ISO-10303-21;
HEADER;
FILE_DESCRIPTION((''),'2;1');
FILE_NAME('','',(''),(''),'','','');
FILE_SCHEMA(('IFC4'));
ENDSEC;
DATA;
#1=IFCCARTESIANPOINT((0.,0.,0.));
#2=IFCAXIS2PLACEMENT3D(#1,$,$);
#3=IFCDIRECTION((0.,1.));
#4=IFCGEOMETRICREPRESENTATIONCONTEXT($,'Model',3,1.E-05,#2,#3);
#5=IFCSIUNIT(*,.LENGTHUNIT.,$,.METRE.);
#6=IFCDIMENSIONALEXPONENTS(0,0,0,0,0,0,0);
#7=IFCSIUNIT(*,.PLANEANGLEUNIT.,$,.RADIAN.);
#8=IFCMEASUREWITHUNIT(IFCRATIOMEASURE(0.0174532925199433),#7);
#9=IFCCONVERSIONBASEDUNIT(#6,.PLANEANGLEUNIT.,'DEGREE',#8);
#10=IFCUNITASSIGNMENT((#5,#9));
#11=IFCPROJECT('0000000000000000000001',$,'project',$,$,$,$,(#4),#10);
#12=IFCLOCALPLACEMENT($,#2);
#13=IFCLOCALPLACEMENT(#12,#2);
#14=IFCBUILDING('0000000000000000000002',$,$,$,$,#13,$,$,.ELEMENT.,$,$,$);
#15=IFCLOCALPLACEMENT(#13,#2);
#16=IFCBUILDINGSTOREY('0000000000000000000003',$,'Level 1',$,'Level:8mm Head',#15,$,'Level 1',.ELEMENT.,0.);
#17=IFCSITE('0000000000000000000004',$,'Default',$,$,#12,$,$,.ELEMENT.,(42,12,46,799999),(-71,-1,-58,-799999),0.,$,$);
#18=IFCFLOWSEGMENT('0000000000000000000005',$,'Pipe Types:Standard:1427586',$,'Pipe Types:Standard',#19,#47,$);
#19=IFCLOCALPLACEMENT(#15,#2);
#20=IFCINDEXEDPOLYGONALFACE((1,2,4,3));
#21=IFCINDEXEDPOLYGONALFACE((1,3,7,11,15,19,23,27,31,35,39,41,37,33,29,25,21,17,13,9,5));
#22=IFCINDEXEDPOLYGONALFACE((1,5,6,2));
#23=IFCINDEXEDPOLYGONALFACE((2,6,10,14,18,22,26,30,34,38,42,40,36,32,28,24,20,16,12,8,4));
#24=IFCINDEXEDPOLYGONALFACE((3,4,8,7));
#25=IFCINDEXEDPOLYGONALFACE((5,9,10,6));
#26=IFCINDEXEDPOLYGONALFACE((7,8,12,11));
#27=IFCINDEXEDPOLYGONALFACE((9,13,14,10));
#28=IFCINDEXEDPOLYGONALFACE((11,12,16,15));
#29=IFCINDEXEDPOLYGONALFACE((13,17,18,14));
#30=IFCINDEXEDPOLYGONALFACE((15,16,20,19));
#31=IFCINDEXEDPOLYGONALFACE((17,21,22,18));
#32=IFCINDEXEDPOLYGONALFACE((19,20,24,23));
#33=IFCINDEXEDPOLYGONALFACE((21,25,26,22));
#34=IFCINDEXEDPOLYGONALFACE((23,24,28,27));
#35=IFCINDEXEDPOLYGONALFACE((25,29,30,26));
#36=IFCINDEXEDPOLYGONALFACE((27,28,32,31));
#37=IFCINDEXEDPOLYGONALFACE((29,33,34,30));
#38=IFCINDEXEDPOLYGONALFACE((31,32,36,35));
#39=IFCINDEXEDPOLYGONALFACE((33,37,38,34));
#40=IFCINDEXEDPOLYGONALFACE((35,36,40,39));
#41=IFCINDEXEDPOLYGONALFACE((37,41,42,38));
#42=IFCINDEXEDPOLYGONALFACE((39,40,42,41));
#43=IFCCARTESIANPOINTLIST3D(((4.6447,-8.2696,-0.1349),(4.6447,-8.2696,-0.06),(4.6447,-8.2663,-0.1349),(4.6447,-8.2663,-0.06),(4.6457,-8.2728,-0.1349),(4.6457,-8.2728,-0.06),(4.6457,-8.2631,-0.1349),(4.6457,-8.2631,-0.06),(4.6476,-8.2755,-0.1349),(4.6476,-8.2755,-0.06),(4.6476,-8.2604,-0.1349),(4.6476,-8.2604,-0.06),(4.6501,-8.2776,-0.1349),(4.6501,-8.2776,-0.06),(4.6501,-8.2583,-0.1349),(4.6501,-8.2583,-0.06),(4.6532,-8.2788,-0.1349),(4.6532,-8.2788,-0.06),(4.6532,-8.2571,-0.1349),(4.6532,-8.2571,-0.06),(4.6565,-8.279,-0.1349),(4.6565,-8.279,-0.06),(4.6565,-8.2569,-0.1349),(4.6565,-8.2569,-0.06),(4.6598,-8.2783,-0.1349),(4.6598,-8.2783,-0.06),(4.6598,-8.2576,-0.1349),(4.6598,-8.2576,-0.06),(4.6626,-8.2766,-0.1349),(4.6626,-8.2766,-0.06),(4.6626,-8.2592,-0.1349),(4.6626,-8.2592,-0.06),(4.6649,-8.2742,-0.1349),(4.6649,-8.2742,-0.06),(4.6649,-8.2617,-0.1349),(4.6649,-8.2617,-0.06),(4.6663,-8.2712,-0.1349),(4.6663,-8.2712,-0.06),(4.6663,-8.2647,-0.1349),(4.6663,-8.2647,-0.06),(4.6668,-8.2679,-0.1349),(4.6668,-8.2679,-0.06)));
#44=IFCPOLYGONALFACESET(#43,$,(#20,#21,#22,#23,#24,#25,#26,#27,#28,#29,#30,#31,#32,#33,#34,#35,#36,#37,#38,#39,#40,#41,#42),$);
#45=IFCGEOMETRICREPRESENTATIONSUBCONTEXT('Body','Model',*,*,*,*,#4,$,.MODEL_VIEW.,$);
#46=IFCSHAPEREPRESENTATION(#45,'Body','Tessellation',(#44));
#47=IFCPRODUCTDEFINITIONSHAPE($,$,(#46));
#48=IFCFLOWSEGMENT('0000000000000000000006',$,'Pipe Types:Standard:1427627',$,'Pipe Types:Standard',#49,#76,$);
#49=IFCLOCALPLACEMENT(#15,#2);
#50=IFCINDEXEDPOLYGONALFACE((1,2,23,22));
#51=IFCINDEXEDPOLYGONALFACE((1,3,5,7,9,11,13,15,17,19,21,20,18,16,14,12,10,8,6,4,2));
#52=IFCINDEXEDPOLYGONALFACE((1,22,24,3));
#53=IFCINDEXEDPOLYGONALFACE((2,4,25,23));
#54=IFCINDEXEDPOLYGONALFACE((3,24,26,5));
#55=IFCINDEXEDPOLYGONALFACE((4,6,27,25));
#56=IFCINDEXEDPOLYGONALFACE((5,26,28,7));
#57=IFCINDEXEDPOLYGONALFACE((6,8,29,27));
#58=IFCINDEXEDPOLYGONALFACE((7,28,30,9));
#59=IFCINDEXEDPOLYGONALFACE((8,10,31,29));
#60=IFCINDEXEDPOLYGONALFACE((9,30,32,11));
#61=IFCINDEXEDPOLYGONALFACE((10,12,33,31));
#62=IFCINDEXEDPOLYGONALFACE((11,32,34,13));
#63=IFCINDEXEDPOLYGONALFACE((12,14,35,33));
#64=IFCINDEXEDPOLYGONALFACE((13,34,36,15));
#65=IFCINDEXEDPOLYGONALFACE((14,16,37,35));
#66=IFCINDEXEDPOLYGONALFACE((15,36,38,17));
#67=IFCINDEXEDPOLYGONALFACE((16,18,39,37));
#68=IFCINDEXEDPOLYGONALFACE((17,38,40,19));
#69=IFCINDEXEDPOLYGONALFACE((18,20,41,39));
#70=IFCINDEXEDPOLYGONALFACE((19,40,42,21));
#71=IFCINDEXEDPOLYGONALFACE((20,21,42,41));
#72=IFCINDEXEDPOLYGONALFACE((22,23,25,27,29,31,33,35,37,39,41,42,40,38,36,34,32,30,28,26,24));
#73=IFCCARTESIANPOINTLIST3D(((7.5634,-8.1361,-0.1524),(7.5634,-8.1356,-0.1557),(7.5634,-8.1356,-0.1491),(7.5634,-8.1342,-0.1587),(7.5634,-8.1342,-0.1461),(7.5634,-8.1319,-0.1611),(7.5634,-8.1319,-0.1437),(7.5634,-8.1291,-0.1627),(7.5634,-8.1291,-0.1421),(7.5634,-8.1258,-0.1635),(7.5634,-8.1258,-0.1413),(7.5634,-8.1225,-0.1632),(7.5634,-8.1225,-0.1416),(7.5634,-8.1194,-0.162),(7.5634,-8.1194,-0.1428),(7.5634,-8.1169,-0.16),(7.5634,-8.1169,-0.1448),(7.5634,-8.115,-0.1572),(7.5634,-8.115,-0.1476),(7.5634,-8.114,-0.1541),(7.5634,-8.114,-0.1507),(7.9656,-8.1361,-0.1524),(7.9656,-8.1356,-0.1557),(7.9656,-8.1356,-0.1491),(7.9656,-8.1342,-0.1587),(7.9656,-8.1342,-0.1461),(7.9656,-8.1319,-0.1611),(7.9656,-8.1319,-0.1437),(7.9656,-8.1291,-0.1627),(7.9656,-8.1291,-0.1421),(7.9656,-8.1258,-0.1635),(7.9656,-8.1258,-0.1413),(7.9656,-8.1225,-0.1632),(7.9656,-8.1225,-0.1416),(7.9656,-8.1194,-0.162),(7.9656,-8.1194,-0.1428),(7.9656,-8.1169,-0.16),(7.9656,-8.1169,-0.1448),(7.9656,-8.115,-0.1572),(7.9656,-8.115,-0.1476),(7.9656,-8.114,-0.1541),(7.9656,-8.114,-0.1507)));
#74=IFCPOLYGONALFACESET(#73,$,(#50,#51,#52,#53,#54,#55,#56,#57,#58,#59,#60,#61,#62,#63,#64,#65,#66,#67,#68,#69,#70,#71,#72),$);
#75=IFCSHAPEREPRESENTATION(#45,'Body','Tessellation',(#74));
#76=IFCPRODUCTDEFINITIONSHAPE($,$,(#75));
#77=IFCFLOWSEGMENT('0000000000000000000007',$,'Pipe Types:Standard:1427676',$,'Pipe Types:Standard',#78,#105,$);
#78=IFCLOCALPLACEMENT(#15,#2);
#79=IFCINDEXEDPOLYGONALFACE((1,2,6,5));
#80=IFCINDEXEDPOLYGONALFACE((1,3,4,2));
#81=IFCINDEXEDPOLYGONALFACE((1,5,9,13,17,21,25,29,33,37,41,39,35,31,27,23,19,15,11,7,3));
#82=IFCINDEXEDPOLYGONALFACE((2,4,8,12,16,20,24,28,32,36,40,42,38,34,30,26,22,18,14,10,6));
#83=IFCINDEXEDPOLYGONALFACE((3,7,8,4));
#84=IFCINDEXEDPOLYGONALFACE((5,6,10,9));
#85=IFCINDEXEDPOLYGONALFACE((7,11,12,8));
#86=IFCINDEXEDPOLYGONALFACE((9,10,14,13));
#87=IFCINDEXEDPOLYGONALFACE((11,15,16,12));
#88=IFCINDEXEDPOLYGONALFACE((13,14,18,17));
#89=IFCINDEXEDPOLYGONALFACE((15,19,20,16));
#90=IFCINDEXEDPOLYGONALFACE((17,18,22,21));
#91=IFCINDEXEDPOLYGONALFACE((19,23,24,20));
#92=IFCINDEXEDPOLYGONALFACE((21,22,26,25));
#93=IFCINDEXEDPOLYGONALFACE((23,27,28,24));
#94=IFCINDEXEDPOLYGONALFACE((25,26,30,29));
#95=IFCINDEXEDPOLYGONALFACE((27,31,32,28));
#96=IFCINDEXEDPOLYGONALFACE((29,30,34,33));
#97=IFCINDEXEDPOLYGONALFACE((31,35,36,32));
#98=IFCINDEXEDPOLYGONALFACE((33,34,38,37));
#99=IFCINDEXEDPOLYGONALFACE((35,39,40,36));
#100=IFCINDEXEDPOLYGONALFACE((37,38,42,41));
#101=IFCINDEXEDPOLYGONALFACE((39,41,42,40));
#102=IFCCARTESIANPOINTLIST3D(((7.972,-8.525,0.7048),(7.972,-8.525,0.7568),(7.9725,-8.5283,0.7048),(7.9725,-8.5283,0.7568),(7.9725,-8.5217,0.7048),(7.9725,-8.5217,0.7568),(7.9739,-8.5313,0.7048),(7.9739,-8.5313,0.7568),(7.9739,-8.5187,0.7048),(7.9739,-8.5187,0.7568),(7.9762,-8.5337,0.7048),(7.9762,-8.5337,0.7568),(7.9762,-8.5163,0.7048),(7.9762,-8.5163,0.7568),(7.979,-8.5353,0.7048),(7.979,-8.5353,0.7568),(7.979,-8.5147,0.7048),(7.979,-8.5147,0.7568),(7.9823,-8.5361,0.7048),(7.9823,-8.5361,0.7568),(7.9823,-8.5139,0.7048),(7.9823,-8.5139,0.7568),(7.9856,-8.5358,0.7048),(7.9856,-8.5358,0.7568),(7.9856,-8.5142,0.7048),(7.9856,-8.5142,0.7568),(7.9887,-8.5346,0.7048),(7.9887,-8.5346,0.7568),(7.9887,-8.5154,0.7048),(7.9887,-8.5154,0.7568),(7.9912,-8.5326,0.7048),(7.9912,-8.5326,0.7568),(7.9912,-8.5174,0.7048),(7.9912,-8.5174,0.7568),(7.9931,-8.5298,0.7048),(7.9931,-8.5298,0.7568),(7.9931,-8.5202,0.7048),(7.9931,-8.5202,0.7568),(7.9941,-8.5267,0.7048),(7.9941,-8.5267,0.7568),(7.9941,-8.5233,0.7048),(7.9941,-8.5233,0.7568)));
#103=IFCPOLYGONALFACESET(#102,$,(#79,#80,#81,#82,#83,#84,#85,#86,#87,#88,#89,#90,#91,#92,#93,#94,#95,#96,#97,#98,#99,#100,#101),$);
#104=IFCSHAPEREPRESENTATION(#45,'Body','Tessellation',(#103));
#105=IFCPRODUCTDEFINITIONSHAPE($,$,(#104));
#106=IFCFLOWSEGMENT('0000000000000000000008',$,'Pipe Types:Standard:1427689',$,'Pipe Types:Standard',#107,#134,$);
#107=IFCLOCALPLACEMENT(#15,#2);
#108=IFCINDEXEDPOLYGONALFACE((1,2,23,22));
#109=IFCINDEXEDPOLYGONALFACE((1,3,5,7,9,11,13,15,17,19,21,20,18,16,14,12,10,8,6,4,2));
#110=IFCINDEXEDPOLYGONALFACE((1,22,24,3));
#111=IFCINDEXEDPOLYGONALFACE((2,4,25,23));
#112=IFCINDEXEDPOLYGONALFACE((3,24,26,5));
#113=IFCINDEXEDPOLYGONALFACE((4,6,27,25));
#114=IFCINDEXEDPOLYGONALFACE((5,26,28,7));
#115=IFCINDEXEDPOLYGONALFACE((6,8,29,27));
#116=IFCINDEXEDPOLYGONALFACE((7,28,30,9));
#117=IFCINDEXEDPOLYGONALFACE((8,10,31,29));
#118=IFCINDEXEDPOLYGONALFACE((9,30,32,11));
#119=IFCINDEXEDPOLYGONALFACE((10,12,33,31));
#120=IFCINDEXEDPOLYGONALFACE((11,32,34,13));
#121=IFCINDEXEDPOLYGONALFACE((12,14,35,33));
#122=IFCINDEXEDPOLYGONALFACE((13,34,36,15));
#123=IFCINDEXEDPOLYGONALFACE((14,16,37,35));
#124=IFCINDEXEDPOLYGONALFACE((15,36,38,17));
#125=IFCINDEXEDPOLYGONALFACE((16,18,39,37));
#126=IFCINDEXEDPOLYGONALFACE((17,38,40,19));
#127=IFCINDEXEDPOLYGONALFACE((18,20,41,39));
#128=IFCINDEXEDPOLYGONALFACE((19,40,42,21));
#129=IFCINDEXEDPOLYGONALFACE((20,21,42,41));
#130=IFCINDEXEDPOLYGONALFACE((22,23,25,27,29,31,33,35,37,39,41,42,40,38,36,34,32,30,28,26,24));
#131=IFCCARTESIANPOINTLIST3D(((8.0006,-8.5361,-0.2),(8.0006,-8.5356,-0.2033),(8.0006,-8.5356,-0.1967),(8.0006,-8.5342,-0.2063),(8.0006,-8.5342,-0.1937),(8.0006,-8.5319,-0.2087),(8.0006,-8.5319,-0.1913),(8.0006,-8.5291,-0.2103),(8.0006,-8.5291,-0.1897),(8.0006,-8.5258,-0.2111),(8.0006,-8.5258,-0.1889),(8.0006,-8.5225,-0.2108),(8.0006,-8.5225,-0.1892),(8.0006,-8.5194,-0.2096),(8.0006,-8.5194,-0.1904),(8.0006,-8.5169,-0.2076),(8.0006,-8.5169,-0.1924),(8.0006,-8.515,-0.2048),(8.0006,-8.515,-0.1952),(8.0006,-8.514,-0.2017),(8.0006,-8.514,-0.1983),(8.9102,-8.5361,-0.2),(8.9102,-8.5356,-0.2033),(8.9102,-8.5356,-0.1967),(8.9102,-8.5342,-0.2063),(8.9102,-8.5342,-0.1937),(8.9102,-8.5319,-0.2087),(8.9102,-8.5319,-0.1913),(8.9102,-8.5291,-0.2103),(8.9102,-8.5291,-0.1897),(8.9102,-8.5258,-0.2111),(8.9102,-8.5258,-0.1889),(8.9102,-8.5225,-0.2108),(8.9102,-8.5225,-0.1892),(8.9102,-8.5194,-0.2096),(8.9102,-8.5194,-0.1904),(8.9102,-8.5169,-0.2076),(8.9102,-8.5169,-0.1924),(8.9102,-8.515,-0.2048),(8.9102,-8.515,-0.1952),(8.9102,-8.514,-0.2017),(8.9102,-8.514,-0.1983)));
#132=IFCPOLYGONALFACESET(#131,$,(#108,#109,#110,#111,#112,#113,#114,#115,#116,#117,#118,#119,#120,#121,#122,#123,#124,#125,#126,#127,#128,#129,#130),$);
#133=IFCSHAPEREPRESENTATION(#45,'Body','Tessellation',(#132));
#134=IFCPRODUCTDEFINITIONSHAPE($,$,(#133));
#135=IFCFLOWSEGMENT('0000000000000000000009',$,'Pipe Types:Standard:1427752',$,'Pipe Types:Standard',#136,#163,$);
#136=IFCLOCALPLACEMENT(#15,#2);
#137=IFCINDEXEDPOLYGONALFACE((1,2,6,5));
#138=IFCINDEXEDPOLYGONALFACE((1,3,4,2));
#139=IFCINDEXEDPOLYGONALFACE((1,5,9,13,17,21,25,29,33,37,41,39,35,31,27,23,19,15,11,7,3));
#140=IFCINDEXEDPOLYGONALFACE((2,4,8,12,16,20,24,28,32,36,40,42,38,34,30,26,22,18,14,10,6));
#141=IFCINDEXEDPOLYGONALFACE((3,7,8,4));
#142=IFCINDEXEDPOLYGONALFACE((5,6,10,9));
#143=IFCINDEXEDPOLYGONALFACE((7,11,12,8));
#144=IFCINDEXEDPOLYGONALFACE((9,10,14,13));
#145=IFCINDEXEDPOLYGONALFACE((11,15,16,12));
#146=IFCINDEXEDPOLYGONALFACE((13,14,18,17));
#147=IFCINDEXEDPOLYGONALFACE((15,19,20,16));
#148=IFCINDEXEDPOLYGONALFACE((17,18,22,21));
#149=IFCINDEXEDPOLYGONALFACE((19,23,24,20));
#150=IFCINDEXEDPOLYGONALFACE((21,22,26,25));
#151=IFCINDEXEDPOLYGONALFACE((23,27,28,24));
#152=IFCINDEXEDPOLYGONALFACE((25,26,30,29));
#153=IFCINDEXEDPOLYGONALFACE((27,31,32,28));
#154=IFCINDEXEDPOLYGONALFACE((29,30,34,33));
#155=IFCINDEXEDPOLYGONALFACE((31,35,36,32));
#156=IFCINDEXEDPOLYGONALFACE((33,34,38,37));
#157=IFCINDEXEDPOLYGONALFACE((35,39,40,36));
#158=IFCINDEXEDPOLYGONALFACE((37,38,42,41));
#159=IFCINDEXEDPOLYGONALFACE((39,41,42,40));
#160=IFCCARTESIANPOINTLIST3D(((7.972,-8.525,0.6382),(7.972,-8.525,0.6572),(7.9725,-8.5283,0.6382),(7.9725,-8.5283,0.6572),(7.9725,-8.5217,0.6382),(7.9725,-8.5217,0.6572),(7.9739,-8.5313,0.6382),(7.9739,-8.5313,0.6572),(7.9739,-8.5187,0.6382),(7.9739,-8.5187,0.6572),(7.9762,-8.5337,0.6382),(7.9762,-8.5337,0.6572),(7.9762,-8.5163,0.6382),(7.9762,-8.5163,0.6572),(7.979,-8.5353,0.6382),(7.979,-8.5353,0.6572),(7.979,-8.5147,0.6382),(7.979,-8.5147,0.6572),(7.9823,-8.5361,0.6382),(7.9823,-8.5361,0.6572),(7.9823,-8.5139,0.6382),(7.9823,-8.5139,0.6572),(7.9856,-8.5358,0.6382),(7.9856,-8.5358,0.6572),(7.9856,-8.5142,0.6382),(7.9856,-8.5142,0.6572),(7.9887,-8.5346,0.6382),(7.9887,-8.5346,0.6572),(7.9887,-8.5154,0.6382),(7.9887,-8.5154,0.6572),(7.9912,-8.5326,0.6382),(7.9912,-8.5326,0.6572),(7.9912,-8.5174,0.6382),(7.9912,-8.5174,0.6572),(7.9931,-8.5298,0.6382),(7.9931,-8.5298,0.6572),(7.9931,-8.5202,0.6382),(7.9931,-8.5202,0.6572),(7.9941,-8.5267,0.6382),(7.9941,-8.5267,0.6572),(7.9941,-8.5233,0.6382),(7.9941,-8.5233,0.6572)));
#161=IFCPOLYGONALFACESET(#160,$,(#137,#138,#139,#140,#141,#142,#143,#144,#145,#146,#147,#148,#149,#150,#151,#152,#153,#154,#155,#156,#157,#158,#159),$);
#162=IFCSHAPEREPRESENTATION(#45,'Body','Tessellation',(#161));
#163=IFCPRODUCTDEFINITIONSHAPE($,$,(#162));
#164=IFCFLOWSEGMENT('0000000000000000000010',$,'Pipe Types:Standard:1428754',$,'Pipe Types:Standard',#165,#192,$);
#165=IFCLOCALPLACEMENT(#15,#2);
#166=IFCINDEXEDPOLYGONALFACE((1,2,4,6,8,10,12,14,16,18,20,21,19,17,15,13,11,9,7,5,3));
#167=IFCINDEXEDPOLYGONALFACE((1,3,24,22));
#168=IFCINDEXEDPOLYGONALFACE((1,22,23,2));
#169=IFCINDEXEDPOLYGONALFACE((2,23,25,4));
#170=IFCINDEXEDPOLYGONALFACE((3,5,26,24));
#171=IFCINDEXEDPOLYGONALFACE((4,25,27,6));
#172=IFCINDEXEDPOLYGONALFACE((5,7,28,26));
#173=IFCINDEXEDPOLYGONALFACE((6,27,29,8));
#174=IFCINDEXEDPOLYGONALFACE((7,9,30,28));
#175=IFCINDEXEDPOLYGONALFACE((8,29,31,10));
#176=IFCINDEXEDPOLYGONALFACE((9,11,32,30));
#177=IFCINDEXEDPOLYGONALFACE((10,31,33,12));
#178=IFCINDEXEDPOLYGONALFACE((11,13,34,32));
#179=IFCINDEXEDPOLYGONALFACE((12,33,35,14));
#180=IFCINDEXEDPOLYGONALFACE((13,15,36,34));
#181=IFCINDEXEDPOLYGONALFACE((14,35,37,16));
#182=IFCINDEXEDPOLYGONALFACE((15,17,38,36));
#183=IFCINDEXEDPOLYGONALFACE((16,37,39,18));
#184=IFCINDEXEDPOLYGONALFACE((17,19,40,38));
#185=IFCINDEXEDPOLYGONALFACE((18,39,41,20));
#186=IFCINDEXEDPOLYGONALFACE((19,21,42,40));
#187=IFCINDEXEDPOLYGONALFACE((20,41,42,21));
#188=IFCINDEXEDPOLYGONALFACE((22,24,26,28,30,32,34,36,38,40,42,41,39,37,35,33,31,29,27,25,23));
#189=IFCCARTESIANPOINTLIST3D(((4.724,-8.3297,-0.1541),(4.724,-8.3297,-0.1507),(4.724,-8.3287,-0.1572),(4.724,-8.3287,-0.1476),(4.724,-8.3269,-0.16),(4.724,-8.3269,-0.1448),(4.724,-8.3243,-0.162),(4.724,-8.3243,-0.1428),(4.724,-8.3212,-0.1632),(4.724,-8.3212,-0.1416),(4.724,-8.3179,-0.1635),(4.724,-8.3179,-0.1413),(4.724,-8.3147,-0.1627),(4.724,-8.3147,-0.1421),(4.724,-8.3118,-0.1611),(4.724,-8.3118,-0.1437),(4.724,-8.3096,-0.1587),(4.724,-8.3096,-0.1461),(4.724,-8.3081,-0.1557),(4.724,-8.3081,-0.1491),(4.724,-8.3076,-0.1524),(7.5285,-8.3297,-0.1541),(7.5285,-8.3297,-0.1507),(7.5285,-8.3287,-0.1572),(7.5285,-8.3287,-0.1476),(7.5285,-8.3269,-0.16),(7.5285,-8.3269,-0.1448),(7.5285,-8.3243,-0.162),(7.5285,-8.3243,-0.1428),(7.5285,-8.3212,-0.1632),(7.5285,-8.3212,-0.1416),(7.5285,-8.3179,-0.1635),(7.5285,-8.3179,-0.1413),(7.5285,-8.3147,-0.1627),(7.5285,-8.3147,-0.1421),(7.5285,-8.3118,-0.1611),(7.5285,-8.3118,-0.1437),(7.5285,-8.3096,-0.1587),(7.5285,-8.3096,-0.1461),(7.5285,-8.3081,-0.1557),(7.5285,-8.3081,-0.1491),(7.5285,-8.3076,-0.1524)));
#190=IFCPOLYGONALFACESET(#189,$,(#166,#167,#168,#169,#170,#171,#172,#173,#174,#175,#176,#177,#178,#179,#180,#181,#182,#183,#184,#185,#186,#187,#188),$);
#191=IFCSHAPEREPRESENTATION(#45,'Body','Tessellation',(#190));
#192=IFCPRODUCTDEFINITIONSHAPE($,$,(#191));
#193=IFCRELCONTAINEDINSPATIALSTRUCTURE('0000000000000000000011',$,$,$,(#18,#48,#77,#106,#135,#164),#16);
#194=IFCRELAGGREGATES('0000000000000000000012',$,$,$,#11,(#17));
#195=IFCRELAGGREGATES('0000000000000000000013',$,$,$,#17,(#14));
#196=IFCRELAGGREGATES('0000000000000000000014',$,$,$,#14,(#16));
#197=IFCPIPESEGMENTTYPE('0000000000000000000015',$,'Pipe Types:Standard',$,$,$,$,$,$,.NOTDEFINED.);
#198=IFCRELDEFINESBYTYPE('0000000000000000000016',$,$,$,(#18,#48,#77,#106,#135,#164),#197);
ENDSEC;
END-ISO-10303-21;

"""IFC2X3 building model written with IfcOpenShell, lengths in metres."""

from ifc_helpers import new_model, entity, si_unit, converted_unit, direction, frame, frame_2d, origin, origin_2d_with_axis, place, context, subcontext, project, spatial, circle, extrude, type_object, element, save


model = new_model("IFC2X3")

# Units and contexts
model_context = context("Model", 3, precision=1e-05, world=origin(), true_north=direction((0.0, 1.0)))
body_context = subcontext(model_context, "Body", "Model", "MODEL_VIEW")
ifc_project = project(units=[si_unit("LENGTHUNIT", "METRE"), converted_unit("PLANEANGLEUNIT", "DEGREE", entity("IfcRatioMeasure", 0.0174532925199433), si_unit("PLANEANGLEUNIT", "RADIAN"), dimensions=[0, 0, 0, 0, 0, 0, 0])], contexts=[model_context])

# Site, building, storey
site_placement = place(None, origin())
site = spatial("IfcSite", under=ifc_project, at=site_placement, Name="Default", CompositionType="ELEMENT", RefLatitude=(42, 12, 46, 799999), RefLongitude=(-71, -1, -58, -799999), RefElevation=0.0)
building_placement = place(site_placement, origin())
building = spatial("IfcBuilding", under=site, at=building_placement, CompositionType="ELEMENT")
storey_placement = place(building_placement, origin())
storey = spatial("IfcBuildingStorey", under=building, at=storey_placement, Name="Level 1", ObjectType="Level:8mm Head", LongName="Level 1", CompositionType="ELEMENT", Elevation=0.0)

# Flow segments
pipe_segment_type = type_object("IfcPipeSegmentType", Name="Pipe Types:Standard", PredefinedType="NOTDEFINED")
flow_segment_1_placement = place(storey_placement, origin())
element("IfcFlowSegment", 1, at=flow_segment_1_placement, inside=storey, type_object=pipe_segment_type, Name="Pipe Types:Standard:1427586", ObjectType="Pipe Types:Standard", context=body_context, shape_type="SweptSolid", body=[
    extrude(circle(Radius=0.0111, at=frame_2d((0.0, 0.0), x_axis=(1.0, 0.0))), frame((4.6557, -8.2679, -0.1349)), (0.0, 0.0, 1.0), 0.075),
])
flow_segment_2_placement = place(storey_placement, origin())
element("IfcFlowSegment", 2, at=flow_segment_2_placement, inside=storey, type_object=pipe_segment_type, Name="Pipe Types:Standard:1427627", ObjectType="Pipe Types:Standard", context=body_context, shape_type="SweptSolid", body=[
    extrude(circle(Radius=0.0111, at=origin_2d_with_axis()), frame((7.5634, -8.125, -0.1524), z_axis=(1.0, 0.0, 0.0), x_axis=(0.0, -1.0, 0.0)), (0.0, 0.0, 1.0), 0.4022),
])
flow_segment_3_placement = place(storey_placement, origin())
element("IfcFlowSegment", 3, at=flow_segment_3_placement, inside=storey, type_object=pipe_segment_type, Name="Pipe Types:Standard:1427676", ObjectType="Pipe Types:Standard", context=body_context, shape_type="SweptSolid", body=[
    extrude(circle(Radius=0.0111, at=frame_2d((0.0, 0.0), x_axis=(1.0, 0.0))), frame((7.9831, -8.525, 0.7048), z_axis=(0.0, 0.0, 1.0), x_axis=(-1.0, 0.0, 0.0)), (0.0, 0.0, 1.0), 0.052),
])
flow_segment_4_placement = place(storey_placement, origin())
element("IfcFlowSegment", 4, at=flow_segment_4_placement, inside=storey, type_object=pipe_segment_type, Name="Pipe Types:Standard:1427689", ObjectType="Pipe Types:Standard", context=body_context, shape_type="SweptSolid", body=[
    extrude(circle(Radius=0.0111, at=origin_2d_with_axis()), frame((8.0006, -8.525, -0.2), z_axis=(1.0, 0.0, 0.0), x_axis=(0.0, -1.0, 0.0)), (0.0, 0.0, 1.0), 0.9096),
])
flow_segment_5_placement = place(storey_placement, origin())
element("IfcFlowSegment", 5, at=flow_segment_5_placement, inside=storey, type_object=pipe_segment_type, Name="Pipe Types:Standard:1427752", ObjectType="Pipe Types:Standard", context=body_context, shape_type="SweptSolid", body=[
    extrude(circle(Radius=0.0111, at=frame_2d((0.0, 0.0), x_axis=(1.0, 0.0))), frame((7.9831, -8.525, 0.6382), z_axis=(0.0, 0.0, 1.0), x_axis=(-1.0, 0.0, 0.0)), (0.0, 0.0, 1.0), 0.019),
])
flow_segment_6_placement = place(storey_placement, origin())
element("IfcFlowSegment", 6, at=flow_segment_6_placement, inside=storey, type_object=pipe_segment_type, Name="Pipe Types:Standard:1428754", ObjectType="Pipe Types:Standard", context=body_context, shape_type="SweptSolid", body=[
    extrude(circle(Radius=0.0111, at=frame_2d((0.0, 0.0), x_axis=(1.0, 0.0))), frame((4.724, -8.3187, -0.1524), z_axis=(1.0, 0.0, 0.0), x_axis=(0.0, 1.0, 0.0)), (0.0, 0.0, 1.0), 2.8045),
])

save(model, "model.ifc")
